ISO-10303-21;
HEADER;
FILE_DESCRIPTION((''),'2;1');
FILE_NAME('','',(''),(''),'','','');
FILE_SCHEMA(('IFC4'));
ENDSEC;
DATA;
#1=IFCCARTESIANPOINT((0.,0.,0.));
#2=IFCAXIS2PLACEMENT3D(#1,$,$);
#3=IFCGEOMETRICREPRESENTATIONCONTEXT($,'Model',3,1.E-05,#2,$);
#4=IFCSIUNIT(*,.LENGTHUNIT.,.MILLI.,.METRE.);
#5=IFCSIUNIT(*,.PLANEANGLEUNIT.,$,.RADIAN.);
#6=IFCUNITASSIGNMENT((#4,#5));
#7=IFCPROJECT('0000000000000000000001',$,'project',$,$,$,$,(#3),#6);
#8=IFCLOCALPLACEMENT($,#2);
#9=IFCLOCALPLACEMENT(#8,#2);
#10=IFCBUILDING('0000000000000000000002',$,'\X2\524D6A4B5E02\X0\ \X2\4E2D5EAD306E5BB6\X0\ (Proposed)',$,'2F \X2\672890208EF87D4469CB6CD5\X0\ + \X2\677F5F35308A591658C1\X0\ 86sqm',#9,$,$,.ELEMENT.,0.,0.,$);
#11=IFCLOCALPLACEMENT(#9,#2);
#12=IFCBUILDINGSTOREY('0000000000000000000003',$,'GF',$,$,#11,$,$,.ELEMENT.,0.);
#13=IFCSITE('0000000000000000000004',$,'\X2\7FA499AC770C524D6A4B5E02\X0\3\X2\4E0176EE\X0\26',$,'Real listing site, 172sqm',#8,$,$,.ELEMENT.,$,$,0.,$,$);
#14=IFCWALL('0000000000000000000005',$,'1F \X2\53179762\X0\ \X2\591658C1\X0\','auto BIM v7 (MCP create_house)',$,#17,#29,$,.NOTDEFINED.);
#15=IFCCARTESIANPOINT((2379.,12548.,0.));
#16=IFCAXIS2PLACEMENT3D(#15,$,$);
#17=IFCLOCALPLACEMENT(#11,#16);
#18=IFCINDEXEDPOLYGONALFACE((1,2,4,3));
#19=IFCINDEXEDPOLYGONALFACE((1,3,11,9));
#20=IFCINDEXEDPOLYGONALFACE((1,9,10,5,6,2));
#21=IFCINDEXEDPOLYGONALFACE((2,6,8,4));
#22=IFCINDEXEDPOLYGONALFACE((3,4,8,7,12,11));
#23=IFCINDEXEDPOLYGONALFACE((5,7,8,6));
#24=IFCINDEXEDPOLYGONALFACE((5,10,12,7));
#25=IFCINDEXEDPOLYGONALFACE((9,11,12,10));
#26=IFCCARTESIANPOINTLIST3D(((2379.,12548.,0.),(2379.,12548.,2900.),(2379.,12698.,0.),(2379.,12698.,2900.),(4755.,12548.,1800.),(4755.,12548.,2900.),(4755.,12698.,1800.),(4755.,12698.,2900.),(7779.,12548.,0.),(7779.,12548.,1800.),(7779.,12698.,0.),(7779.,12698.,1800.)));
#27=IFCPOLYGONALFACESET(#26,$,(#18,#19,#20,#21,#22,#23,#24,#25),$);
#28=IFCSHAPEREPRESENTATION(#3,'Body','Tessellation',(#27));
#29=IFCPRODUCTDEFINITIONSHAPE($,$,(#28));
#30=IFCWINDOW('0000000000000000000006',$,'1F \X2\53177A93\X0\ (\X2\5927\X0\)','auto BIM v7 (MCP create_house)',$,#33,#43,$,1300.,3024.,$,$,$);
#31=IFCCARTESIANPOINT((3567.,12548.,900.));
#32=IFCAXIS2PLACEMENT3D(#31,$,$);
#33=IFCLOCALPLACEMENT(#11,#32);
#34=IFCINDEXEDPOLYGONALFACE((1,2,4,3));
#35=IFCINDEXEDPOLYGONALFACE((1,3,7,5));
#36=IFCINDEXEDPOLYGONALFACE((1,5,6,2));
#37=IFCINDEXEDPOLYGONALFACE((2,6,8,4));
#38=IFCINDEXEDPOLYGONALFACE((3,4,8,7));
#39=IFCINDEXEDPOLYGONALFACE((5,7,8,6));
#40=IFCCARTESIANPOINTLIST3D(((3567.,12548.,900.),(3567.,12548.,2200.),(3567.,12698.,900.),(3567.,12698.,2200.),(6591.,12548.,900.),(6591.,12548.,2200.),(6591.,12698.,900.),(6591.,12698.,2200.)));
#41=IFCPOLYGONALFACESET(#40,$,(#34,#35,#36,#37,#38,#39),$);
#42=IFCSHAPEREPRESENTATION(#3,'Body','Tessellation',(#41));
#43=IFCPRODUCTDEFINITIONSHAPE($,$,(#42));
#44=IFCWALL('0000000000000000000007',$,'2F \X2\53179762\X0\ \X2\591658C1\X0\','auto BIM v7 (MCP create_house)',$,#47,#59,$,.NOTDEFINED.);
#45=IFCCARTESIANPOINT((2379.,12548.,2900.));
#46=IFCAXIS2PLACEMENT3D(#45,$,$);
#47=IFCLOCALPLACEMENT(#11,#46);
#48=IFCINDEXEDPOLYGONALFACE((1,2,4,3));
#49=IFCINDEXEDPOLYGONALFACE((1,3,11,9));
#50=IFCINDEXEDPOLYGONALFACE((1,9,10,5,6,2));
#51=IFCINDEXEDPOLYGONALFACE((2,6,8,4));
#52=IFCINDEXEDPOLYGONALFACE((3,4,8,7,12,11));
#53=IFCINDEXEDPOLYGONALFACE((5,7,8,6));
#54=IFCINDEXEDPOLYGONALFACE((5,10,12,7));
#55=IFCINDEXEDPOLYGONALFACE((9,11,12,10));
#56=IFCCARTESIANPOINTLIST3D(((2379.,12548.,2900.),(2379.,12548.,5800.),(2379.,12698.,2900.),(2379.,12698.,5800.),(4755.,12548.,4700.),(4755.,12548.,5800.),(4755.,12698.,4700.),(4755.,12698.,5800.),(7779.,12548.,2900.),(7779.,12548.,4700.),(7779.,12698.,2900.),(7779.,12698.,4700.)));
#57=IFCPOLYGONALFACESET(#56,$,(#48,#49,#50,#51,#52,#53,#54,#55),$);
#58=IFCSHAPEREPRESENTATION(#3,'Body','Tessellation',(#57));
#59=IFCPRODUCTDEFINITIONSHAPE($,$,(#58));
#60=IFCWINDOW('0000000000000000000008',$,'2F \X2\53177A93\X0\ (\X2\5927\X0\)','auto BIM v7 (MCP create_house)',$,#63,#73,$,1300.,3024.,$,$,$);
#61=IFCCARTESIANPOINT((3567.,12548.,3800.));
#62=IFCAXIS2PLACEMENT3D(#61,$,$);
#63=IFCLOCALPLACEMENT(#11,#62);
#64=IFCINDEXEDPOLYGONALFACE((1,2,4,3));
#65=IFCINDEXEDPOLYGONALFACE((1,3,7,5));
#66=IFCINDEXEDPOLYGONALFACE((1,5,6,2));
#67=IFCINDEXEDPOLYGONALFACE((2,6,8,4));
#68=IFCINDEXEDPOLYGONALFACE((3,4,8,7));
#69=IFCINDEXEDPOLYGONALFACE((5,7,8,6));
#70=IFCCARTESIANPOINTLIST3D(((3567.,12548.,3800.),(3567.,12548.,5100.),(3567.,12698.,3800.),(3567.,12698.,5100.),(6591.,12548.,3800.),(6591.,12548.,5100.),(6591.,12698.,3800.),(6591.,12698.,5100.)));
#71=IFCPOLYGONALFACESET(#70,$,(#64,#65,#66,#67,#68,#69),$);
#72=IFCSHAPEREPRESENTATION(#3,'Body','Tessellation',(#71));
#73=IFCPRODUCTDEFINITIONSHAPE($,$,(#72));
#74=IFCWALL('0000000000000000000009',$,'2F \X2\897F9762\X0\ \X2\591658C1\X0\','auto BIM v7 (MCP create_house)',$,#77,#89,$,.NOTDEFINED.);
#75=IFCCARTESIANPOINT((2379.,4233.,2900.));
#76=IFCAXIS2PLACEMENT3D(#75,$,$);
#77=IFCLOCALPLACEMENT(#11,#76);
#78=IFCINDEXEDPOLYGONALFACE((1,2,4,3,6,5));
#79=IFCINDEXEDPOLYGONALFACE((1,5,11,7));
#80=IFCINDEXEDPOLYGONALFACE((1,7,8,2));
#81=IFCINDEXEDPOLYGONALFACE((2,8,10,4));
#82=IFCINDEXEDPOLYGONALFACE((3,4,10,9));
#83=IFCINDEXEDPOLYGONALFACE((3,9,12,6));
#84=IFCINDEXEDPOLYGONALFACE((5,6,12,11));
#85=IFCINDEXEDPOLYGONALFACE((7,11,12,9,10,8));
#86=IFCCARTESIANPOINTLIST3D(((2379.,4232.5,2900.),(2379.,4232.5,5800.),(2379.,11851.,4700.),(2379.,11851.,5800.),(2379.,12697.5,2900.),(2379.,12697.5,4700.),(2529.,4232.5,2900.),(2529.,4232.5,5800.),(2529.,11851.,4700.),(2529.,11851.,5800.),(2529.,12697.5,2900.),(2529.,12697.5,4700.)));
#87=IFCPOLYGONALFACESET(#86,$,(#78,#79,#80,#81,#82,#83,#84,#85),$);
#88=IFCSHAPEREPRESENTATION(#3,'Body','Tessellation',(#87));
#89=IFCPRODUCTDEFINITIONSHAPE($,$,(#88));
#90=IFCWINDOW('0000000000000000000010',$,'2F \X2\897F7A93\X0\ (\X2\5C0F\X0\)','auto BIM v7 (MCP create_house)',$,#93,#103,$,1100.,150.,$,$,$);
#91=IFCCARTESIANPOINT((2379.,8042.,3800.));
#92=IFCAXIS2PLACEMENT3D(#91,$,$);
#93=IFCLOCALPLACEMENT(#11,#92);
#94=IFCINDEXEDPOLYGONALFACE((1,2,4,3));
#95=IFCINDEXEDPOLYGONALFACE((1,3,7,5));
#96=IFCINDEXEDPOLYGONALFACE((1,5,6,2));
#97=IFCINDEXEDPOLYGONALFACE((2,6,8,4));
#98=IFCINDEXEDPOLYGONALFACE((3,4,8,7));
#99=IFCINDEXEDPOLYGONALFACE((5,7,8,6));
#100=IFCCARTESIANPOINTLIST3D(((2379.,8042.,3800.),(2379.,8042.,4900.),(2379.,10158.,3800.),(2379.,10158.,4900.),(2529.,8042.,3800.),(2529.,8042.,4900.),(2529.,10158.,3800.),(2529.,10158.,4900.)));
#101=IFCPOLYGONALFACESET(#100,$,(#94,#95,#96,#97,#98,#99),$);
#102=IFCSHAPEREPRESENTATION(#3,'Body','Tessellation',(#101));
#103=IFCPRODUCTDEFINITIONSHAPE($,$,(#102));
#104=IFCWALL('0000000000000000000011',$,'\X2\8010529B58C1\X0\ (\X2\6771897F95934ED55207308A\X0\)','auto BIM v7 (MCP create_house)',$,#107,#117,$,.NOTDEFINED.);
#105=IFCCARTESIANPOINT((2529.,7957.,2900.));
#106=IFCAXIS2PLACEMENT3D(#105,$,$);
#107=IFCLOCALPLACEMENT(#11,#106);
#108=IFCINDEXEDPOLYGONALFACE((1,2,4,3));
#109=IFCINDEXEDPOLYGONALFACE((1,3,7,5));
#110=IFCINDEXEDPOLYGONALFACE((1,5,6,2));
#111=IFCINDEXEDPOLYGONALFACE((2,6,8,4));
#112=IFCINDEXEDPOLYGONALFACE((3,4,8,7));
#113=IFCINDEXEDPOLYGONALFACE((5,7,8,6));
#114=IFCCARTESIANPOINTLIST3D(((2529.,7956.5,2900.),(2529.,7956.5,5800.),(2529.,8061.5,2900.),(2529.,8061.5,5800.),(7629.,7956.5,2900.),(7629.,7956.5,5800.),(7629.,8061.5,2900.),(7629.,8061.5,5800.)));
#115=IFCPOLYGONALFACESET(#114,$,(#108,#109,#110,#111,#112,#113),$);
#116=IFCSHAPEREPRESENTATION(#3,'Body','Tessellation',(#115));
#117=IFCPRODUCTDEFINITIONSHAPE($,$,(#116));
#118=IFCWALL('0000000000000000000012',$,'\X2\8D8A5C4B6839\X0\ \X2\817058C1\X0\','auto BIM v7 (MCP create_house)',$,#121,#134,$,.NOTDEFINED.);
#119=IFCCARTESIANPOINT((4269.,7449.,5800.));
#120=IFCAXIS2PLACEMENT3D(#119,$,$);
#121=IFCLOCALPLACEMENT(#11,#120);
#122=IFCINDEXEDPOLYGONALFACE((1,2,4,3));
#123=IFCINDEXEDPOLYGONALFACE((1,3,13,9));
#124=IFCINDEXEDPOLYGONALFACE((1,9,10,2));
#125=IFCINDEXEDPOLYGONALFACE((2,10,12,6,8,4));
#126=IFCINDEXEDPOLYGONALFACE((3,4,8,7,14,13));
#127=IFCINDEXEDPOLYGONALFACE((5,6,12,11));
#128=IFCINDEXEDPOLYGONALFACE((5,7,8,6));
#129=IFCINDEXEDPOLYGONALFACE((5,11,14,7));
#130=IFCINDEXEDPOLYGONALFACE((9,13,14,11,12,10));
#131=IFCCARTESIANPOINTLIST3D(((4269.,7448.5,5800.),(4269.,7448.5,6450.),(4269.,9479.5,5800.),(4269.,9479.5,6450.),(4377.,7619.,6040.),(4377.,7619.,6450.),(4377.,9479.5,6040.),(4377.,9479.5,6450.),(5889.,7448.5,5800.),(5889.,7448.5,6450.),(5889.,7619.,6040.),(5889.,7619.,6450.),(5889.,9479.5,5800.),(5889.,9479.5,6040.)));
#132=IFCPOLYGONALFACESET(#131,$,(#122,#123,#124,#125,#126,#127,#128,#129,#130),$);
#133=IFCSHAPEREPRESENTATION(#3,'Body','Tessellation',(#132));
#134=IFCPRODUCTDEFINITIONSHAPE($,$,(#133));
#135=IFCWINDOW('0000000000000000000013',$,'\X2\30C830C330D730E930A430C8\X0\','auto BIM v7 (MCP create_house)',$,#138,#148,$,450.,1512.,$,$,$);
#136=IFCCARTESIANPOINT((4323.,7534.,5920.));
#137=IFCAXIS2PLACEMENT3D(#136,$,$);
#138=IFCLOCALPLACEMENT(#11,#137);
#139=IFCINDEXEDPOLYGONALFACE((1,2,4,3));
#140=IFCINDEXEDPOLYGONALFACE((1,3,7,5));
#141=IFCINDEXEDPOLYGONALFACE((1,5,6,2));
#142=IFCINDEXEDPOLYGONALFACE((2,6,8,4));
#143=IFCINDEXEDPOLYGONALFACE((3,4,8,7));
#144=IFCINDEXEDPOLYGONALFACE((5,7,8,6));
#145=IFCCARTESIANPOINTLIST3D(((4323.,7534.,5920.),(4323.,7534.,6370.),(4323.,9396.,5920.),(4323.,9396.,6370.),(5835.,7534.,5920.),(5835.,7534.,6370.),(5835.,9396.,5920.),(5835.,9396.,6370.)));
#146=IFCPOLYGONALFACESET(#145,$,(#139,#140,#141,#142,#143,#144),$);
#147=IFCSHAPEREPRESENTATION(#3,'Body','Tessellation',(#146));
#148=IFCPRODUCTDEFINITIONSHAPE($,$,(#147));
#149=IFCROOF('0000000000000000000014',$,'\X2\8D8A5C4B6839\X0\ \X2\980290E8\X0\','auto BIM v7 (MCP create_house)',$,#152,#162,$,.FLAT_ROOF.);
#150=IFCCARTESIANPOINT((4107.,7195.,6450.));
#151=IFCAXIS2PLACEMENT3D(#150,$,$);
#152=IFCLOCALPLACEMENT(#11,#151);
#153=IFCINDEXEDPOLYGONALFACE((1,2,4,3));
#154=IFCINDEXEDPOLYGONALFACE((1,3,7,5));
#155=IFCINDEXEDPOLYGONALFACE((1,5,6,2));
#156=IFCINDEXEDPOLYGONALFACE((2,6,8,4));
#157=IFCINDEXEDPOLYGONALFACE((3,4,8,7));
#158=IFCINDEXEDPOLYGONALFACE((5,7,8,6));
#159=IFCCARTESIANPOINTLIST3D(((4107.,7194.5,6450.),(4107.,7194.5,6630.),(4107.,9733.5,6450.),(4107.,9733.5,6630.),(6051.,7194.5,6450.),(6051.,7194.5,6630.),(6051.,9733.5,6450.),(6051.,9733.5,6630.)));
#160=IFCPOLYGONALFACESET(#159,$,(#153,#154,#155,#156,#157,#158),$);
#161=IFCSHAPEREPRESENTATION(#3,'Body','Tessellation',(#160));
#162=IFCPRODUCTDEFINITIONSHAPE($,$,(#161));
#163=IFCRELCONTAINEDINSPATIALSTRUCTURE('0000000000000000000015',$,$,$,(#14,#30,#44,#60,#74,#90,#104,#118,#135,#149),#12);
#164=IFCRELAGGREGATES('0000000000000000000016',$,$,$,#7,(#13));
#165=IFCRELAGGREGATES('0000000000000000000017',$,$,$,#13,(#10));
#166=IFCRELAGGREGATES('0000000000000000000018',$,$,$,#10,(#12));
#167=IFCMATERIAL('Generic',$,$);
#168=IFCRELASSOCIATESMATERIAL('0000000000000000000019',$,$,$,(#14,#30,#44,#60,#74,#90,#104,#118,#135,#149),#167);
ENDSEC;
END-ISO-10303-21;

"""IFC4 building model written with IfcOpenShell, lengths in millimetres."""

from ifc_helpers import new_model, si_unit, frame, frame_2d, origin, place, context, project, spatial, rectangle, extrude, material, element, fill, save


model = new_model("IFC4")

# Units and contexts
model_context = context("Model", 3, precision=1e-05, world=origin())
ifc_project = project(units=[si_unit("LENGTHUNIT", "METRE", prefix="MILLI"), si_unit("PLANEANGLEUNIT", "RADIAN")], contexts=[model_context])

# Site, building, storey
site_placement = place(None, origin())
site = spatial("IfcSite", under=ifc_project, at=site_placement, Name="群馬県前橋市3丁目26", ObjectType="Real listing site, 172sqm", CompositionType="ELEMENT", RefElevation=0.0)
building_placement = place(site_placement, origin())
building = spatial("IfcBuilding", under=site, at=building_placement, Name="前橋市 中庭の家 (Proposed)", ObjectType="2F 木造軸組構法 + 板張り外壁 86sqm", CompositionType="ELEMENT", ElevationOfRefHeight=0.0, ElevationOfTerrain=0.0)
storey_placement = place(building_placement, origin())
storey = spatial("IfcBuildingStorey", under=building, at=storey_placement, Name="GF", CompositionType="ELEMENT", Elevation=0.0)

# Wall, opening, window
ifc_material = material(Name="Generic")
wall_1_placement = place(storey_placement, frame((2379.0, 12548.0, 0.0)))
wall_1 = element("IfcWall", 1, at=wall_1_placement, inside=storey, material=ifc_material, Name="1F 北面 外壁", Description="auto BIM v7 (MCP create_house)", PredefinedType="NOTDEFINED", context=model_context, shape_type="SweptSolid", body=[
    extrude(rectangle(XDim=5400.0, YDim=150.0, at=frame_2d((2700.0, 75.0))), frame((2379.0, 12548.0, 0.0)), (0.0, 0.0, 1.0), 2900.0),
])
opening_1_placement = place(storey_placement, frame((3567.0, 12548.0, 900.0)))
opening_1 = element("IfcOpeningElement", 2, at=opening_1_placement, cuts=wall_1, PredefinedType="NOTDEFINED", context=model_context, shape_type="SweptSolid", body=[
    extrude(rectangle(XDim=3024.0, YDim=150.0, at=frame_2d((1512.0, 75.0))), frame((3567.0, 12548.0, 900.0)), (0.0, 0.0, 1.0), 1300.0),
])
window_1_placement = place(storey_placement, frame((3567.0, 12548.0, 900.0)))
window_1 = element("IfcWindow", 3, at=window_1_placement, inside=storey, material=ifc_material, Name="1F 北窓 (大)", Description="auto BIM v7 (MCP create_house)", OverallHeight=1300.0, OverallWidth=3024.0, context=model_context, shape_type="SweptSolid", body=[
    extrude(rectangle(XDim=3024.0, YDim=150.0, at=frame_2d((1512.0, 75.0))), frame((3567.0, 12548.0, 900.0)), (0.0, 0.0, 1.0), 1300.0),
])
fill(opening_1, window_1)

# Walls, openings, windows
wall_2_placement = place(storey_placement, frame((2379.0, 12548.0, 2900.0)))
wall_2 = element("IfcWall", 4, at=wall_2_placement, inside=storey, material=ifc_material, Name="2F 北面 外壁", Description="auto BIM v7 (MCP create_house)", PredefinedType="NOTDEFINED", context=model_context, shape_type="SweptSolid", body=[
    extrude(rectangle(XDim=5400.0, YDim=150.0, at=frame_2d((2700.0, 75.0))), frame((2379.0, 12548.0, 2900.0)), (0.0, 0.0, 1.0), 2900.0),
])
opening_2_placement = place(storey_placement, frame((3567.0, 12548.0, 3800.0)))
opening_2 = element("IfcOpeningElement", 5, at=opening_2_placement, cuts=wall_2, PredefinedType="NOTDEFINED", context=model_context, shape_type="SweptSolid", body=[
    extrude(rectangle(XDim=3024.0, YDim=150.0, at=frame_2d((1512.0, 75.0))), frame((3567.0, 12548.0, 3800.0)), (0.0, 0.0, 1.0), 1300.0),
])
window_2_placement = place(storey_placement, frame((3567.0, 12548.0, 3800.0)))
window_2 = element("IfcWindow", 6, at=window_2_placement, inside=storey, material=ifc_material, Name="2F 北窓 (大)", Description="auto BIM v7 (MCP create_house)", OverallHeight=1300.0, OverallWidth=3024.0, context=model_context, shape_type="SweptSolid", body=[
    extrude(rectangle(XDim=3024.0, YDim=150.0, at=frame_2d((1512.0, 75.0))), frame((3567.0, 12548.0, 3800.0)), (0.0, 0.0, 1.0), 1300.0),
])
fill(opening_2, window_2)
wall_3_placement = place(storey_placement, frame((2379.0, 4233.0, 2900.0)))
wall_3 = element("IfcWall", 7, at=wall_3_placement, inside=storey, material=ifc_material, Name="2F 西面 外壁", Description="auto BIM v7 (MCP create_house)", PredefinedType="NOTDEFINED", context=model_context, shape_type="SweptSolid", body=[
    extrude(rectangle(XDim=150.0, YDim=8465.0, at=frame_2d((75.0, 4232.0))), frame((2379.0, 4233.0, 2900.0)), (0.0, 0.0, 1.0), 2900.0),
])
opening_3_placement = place(storey_placement, frame((2379.0, 8042.0, 3800.0)))
opening_3 = element("IfcOpeningElement", 8, at=opening_3_placement, cuts=wall_3, PredefinedType="NOTDEFINED", context=model_context, shape_type="SweptSolid", body=[
    extrude(rectangle(XDim=150.0, YDim=2116.0, at=frame_2d((75.0, 1058.0))), frame((2379.0, 8042.0, 3800.0)), (0.0, 0.0, 1.0), 1100.0),
])
window_3_placement = place(storey_placement, frame((2379.0, 8042.0, 3800.0)))
window_3 = element("IfcWindow", 9, at=window_3_placement, inside=storey, material=ifc_material, Name="2F 西窓 (小)", Description="auto BIM v7 (MCP create_house)", OverallHeight=1100.0, OverallWidth=150.0, context=model_context, shape_type="SweptSolid", body=[
    extrude(rectangle(XDim=150.0, YDim=2116.0, at=frame_2d((75.0, 1058.0))), frame((2379.0, 8042.0, 3800.0)), (0.0, 0.0, 1.0), 1100.0),
])
fill(opening_3, window_3)

# Wall
wall_4_placement = place(storey_placement, frame((2529.0, 7957.0, 2900.0)))
element("IfcWall", 10, at=wall_4_placement, inside=storey, material=ifc_material, Name="耐力壁 (東西間仕切り)", Description="auto BIM v7 (MCP create_house)", PredefinedType="NOTDEFINED", context=model_context, shape_type="SweptSolid", body=[
    extrude(rectangle(XDim=5100.0, YDim=105.0, at=frame_2d((2550.0, 52.0))), frame((2529.0, 7957.0, 2900.0)), (0.0, 0.0, 1.0), 2900.0),
])

# Wall, opening, window
wall_5_placement = place(storey_placement, frame((4269.0, 7449.0, 5800.0)))
wall_5 = element("IfcWall", 11, at=wall_5_placement, inside=storey, material=ifc_material, Name="越屋根 腰壁", Description="auto BIM v7 (MCP create_house)", PredefinedType="NOTDEFINED", context=model_context, shape_type="SweptSolid", body=[
    extrude(rectangle(XDim=1620.0, YDim=2031.0, at=frame_2d((810.0, 1015.0))), frame((4269.0, 7449.0, 5800.0)), (0.0, 0.0, 1.0), 650.0),
])
opening_4_placement = place(storey_placement, frame((4323.0, 7534.0, 5920.0)))
opening_4 = element("IfcOpeningElement", 12, at=opening_4_placement, cuts=wall_5, PredefinedType="NOTDEFINED", context=model_context, shape_type="SweptSolid", body=[
    extrude(rectangle(XDim=1512.0, YDim=1862.0, at=frame_2d((756.0, 931.0))), frame((4323.0, 7534.0, 5920.0)), (0.0, 0.0, 1.0), 450.0),
])
window_4_placement = place(storey_placement, frame((4323.0, 7534.0, 5920.0)))
window_4 = element("IfcWindow", 13, at=window_4_placement, inside=storey, material=ifc_material, Name="トップライト", Description="auto BIM v7 (MCP create_house)", OverallHeight=450.0, OverallWidth=1512.0, context=model_context, shape_type="SweptSolid", body=[
    extrude(rectangle(XDim=1512.0, YDim=1862.0, at=frame_2d((756.0, 931.0))), frame((4323.0, 7534.0, 5920.0)), (0.0, 0.0, 1.0), 450.0),
])
fill(opening_4, window_4)

# Roof
roof_placement = place(storey_placement, frame((4107.0, 7195.0, 6450.0)))
element("IfcRoof", 14, at=roof_placement, inside=storey, material=ifc_material, Name="越屋根 頂部", Description="auto BIM v7 (MCP create_house)", PredefinedType="FLAT_ROOF", context=model_context, shape_type="SweptSolid", body=[
    extrude(rectangle(XDim=1944.0, YDim=2539.0, at=frame_2d((972.0, 1269.0))), frame((4107.0, 7195.0, 6450.0)), (0.0, 0.0, 1.0), 180.0),
])

save(model, "model.ifc")
